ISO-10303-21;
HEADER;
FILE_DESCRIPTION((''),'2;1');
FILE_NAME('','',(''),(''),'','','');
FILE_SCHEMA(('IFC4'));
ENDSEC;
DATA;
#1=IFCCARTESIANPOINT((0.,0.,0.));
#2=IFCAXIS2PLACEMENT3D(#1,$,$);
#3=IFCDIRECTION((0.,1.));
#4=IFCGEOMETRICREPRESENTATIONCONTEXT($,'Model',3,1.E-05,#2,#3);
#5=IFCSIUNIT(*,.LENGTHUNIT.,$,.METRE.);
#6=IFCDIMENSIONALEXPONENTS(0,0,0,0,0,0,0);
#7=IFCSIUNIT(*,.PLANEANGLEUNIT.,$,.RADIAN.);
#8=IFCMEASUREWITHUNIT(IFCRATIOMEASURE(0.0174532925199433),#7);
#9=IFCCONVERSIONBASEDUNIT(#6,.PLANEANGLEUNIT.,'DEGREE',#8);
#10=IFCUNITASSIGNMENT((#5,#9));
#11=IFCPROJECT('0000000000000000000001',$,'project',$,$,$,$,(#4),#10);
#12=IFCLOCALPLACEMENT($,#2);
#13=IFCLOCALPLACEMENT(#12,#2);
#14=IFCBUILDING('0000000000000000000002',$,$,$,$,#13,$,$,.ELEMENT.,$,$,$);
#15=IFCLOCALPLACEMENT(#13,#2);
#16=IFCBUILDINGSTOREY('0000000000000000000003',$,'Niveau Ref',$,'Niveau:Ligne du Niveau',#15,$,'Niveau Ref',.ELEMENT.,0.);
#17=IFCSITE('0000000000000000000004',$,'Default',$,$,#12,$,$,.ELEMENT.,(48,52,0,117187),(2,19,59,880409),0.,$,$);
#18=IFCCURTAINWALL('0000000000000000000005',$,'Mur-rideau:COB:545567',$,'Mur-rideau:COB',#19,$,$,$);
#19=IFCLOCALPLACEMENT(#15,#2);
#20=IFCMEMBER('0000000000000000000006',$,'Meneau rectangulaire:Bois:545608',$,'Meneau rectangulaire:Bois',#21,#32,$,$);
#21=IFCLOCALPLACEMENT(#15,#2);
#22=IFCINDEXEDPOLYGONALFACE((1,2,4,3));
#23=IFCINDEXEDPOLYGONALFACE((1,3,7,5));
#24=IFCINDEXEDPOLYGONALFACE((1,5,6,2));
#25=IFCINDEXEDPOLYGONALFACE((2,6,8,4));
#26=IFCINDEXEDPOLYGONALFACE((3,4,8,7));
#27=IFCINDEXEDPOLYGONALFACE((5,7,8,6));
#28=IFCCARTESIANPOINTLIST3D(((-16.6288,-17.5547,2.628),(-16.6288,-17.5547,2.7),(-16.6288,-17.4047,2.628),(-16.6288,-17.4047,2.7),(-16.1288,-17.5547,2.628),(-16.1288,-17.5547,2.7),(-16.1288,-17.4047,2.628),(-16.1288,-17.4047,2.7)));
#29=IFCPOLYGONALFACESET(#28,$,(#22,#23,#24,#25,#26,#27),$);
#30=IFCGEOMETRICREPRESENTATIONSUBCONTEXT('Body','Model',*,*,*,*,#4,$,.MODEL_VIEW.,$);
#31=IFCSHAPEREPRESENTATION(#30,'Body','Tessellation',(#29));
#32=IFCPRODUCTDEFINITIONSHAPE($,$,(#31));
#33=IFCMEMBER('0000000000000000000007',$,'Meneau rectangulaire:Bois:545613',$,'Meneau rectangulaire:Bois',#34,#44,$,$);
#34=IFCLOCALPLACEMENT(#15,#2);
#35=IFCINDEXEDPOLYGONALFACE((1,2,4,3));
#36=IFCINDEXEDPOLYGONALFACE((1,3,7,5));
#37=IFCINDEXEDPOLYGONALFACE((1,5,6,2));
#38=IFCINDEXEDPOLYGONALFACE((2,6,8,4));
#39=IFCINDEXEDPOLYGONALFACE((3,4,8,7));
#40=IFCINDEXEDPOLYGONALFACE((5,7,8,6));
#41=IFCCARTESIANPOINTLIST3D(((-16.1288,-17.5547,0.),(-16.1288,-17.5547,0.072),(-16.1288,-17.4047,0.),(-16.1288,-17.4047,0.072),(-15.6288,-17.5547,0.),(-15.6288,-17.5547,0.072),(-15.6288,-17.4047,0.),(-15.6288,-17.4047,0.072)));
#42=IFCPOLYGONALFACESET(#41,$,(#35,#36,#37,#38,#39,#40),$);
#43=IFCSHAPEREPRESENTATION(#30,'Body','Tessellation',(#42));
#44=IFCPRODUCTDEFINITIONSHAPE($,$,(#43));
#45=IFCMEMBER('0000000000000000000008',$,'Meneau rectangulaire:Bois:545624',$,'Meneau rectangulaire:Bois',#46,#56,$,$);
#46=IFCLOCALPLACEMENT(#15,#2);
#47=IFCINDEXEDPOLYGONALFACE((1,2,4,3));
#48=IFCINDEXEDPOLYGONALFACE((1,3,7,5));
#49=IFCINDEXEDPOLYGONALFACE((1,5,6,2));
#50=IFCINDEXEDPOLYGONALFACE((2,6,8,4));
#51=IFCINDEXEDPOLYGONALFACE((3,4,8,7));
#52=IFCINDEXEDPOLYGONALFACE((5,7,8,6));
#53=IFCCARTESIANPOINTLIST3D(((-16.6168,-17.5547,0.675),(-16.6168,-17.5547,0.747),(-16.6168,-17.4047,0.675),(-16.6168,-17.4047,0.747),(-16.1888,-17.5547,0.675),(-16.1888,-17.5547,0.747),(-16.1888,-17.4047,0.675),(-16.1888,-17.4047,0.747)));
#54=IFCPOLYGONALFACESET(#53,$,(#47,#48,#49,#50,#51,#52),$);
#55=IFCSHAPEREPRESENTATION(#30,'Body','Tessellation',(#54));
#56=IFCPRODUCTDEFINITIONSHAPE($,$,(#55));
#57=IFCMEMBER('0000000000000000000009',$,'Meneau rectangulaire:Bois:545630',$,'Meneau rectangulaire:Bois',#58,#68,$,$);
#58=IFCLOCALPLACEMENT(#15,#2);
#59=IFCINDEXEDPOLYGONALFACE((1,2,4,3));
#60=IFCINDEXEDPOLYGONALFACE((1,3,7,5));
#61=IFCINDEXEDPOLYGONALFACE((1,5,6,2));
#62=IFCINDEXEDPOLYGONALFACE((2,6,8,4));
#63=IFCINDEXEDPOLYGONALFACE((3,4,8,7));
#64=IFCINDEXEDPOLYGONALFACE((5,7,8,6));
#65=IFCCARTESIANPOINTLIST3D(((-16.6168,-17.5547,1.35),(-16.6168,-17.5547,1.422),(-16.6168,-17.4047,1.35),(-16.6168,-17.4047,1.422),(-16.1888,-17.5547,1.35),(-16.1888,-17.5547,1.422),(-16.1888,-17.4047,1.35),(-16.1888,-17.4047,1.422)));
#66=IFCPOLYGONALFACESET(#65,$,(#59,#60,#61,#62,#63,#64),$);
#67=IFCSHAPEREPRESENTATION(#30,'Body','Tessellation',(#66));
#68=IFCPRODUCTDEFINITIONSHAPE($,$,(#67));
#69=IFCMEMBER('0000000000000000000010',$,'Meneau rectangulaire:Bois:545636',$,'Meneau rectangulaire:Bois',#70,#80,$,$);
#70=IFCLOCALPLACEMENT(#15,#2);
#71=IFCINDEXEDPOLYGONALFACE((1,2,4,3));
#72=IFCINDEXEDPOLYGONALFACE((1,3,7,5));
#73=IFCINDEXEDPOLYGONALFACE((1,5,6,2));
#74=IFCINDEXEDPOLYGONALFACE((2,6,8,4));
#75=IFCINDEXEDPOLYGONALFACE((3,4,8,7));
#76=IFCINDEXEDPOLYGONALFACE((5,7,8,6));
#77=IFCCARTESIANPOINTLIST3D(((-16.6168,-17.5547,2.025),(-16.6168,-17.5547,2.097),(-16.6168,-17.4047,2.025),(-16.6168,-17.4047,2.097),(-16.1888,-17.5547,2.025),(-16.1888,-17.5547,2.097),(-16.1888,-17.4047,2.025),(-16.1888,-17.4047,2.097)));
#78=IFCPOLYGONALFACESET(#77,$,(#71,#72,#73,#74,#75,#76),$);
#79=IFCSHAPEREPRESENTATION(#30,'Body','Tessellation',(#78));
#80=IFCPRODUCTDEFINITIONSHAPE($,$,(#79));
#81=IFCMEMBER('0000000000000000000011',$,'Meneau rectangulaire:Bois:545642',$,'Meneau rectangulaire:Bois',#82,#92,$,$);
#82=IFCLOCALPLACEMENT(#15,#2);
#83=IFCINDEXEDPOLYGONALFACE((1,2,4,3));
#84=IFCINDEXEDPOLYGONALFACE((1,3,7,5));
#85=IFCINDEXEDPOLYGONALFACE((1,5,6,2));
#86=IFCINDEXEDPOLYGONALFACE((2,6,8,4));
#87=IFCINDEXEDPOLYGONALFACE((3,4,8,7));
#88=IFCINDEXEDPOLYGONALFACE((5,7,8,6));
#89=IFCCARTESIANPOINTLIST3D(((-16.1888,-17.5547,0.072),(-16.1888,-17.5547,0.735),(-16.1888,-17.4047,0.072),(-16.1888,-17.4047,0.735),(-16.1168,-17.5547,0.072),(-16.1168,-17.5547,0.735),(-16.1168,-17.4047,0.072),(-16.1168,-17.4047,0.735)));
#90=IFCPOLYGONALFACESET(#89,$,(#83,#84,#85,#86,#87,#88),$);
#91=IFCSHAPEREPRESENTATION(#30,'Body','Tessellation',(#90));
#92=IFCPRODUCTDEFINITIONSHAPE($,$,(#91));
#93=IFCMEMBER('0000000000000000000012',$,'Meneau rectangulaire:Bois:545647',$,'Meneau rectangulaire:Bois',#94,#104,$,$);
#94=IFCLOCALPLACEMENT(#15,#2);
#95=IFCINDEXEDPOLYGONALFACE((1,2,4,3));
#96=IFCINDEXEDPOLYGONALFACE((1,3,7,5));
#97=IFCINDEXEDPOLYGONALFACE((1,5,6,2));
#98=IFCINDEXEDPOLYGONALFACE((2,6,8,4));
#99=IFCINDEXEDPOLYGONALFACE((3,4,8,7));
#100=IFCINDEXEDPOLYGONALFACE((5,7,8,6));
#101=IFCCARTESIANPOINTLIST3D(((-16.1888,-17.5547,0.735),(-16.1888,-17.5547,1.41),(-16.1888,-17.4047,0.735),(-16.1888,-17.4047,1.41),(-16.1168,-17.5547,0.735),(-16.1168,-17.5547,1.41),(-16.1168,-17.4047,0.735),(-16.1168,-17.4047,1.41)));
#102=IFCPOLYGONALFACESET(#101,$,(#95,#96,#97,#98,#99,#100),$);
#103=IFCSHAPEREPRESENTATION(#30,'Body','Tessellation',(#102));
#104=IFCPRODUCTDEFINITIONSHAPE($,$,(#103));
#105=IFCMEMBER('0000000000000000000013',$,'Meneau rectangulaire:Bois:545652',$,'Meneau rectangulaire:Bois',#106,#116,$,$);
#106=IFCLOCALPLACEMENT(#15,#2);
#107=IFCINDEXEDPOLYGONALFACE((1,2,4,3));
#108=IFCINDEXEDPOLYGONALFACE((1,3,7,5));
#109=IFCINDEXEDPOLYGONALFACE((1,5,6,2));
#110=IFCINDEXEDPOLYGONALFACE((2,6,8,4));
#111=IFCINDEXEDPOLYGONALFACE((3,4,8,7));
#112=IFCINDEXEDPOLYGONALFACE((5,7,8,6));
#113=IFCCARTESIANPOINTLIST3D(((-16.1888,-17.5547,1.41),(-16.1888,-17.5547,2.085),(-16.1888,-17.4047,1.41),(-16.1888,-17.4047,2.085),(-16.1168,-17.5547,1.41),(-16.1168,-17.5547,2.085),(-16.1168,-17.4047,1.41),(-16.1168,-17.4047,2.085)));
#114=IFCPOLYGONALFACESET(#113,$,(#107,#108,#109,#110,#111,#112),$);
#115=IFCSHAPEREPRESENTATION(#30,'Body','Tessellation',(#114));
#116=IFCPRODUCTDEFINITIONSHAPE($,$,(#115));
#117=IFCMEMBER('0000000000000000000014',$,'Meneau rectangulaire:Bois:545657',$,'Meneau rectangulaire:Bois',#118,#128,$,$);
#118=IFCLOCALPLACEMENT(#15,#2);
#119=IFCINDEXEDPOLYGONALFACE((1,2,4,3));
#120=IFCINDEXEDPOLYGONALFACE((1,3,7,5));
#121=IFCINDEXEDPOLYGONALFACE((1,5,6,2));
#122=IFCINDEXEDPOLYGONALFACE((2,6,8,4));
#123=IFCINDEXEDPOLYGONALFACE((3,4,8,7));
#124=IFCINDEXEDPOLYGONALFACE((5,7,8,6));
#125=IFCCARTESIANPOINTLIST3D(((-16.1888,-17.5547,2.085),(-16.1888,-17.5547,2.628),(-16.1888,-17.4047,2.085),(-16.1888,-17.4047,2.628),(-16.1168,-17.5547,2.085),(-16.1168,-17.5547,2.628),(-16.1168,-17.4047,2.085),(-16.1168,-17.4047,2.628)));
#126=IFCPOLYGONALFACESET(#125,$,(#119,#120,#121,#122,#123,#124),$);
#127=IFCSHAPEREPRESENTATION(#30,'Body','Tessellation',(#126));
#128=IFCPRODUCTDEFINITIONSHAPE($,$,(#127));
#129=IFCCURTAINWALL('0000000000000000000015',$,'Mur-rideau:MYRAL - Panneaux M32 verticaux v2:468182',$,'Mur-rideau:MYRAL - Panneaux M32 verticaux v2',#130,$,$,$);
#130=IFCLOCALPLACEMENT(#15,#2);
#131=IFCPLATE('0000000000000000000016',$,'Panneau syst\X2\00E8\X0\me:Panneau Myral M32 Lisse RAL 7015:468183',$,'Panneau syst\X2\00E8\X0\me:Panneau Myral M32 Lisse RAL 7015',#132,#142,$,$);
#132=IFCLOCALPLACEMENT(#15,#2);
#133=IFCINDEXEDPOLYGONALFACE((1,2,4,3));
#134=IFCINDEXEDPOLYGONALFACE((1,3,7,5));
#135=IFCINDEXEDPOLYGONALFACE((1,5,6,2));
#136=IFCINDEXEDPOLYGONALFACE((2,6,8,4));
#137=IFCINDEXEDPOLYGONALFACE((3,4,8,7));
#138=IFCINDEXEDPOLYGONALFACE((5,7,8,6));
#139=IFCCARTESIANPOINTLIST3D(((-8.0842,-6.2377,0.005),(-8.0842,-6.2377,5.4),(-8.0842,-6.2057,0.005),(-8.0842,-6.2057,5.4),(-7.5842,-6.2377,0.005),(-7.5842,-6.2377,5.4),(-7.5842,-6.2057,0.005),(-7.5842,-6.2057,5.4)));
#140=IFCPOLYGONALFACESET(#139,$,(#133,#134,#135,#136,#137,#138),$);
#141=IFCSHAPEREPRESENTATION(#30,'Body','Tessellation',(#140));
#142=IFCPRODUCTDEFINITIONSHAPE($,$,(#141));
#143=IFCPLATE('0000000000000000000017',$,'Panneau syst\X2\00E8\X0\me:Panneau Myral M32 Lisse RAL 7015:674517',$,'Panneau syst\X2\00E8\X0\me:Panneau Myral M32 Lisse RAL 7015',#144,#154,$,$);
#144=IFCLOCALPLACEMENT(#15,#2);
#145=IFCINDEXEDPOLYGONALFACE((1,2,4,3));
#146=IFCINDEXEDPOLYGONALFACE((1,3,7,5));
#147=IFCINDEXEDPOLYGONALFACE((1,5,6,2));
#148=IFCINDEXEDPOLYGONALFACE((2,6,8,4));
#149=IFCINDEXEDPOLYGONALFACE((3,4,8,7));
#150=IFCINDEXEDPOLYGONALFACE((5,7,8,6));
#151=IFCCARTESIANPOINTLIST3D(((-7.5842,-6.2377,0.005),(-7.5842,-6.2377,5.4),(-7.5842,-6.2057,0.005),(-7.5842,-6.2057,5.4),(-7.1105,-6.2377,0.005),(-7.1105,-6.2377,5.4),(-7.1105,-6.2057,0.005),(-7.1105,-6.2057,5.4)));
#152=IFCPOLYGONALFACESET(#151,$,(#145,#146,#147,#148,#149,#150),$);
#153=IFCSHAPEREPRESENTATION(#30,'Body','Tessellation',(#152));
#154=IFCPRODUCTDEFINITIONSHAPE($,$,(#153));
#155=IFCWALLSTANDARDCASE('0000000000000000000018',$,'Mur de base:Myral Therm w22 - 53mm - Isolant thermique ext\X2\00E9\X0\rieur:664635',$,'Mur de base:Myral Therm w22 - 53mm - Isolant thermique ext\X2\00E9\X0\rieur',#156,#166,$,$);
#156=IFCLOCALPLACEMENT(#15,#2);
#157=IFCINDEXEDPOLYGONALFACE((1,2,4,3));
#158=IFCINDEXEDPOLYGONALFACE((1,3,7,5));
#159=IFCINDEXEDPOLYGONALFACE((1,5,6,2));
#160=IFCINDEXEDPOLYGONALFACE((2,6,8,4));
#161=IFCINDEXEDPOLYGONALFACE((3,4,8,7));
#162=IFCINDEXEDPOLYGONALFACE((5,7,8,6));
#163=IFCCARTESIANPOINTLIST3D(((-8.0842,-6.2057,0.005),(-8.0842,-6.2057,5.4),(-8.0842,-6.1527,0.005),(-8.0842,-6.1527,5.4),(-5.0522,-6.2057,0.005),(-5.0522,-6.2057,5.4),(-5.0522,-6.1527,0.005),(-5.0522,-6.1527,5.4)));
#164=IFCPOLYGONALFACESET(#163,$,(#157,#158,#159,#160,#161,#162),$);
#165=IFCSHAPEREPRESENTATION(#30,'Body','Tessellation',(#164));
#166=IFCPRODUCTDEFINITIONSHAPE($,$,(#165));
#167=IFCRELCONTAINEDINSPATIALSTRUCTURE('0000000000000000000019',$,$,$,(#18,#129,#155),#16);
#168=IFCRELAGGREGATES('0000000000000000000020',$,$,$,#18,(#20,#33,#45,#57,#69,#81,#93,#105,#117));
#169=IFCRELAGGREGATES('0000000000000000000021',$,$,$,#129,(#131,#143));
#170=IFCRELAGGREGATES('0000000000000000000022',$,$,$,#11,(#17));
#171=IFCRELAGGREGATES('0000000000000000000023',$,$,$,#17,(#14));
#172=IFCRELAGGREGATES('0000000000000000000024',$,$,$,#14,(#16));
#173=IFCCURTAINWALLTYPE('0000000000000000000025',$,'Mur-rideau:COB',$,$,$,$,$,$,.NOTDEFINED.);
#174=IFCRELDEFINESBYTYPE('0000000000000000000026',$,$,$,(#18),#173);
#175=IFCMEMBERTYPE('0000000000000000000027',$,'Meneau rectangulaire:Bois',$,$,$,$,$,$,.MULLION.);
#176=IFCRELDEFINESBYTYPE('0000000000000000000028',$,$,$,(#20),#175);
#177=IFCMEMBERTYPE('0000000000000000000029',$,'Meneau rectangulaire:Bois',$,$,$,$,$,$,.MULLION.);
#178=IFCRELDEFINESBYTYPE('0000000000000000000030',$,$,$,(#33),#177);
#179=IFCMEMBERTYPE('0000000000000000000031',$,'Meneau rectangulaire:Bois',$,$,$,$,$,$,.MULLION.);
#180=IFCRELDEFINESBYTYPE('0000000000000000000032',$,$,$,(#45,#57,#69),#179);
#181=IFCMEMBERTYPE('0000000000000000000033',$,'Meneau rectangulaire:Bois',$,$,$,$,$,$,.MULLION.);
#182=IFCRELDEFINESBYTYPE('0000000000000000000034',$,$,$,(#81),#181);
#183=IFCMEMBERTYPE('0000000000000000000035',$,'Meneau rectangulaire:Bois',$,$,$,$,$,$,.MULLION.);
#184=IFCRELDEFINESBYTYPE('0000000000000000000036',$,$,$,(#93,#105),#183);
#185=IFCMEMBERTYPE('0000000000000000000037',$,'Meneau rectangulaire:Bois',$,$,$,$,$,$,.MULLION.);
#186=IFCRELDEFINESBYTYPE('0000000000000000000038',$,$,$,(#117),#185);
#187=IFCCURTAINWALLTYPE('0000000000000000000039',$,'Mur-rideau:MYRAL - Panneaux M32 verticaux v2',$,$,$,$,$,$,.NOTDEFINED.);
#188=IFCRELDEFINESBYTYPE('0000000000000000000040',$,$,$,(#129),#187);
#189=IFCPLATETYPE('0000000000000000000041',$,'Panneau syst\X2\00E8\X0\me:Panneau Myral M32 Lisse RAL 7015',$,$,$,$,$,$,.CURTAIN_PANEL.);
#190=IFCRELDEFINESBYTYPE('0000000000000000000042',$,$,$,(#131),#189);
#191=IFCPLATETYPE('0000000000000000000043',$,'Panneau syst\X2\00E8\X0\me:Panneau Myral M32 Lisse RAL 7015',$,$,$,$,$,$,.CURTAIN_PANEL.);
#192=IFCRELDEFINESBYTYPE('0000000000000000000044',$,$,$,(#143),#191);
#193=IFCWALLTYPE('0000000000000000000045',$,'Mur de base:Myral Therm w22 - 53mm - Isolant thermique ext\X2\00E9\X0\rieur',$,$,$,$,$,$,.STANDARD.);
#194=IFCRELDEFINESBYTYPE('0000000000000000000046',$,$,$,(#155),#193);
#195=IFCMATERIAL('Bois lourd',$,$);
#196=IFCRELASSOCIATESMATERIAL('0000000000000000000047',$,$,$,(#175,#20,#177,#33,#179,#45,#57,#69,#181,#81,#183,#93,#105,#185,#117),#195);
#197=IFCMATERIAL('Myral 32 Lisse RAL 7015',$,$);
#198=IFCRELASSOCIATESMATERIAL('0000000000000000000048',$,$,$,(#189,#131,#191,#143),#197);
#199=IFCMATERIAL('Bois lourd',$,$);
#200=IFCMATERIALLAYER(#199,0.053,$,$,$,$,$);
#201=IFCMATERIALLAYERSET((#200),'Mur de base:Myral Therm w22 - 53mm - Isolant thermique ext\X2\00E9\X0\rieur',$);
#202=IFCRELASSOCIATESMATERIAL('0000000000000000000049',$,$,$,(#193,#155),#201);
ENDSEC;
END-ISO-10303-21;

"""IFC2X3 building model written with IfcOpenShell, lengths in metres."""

from ifc_helpers import new_model, entity, si_unit, converted_unit, direction, frame, frame_2d, origin, origin_2d_with_axis, place, context, subcontext, project, spatial, rectangle, extrude, source, transform, mapped, material, layer, layer_set, layer_usage, type_object, type_shapes, element, aggregate, save


model = new_model("IFC2X3")

# Units and contexts
model_context = context("Model", 3, precision=1e-05, world=origin(), true_north=direction((0.0, 1.0)))
body_context = subcontext(model_context, "Body", "Model", "MODEL_VIEW")
ifc_project = project(units=[si_unit("LENGTHUNIT", "METRE"), converted_unit("PLANEANGLEUNIT", "DEGREE", entity("IfcRatioMeasure", 0.0174532925199433), si_unit("PLANEANGLEUNIT", "RADIAN"), dimensions=[0, 0, 0, 0, 0, 0, 0])], contexts=[model_context])

# Site, building, storey
site_placement = place(None, origin())
site = spatial("IfcSite", under=ifc_project, at=site_placement, Name="Default", CompositionType="ELEMENT", RefLatitude=(48, 52, 0, 117187), RefLongitude=(2, 19, 59, 880409), RefElevation=0.0)
building_placement = place(site_placement, origin())
building = spatial("IfcBuilding", under=site, at=building_placement, CompositionType="ELEMENT")
storey_placement = place(building_placement, origin())
storey = spatial("IfcBuildingStorey", under=building, at=storey_placement, Name="Niveau Ref", ObjectType="Niveau:Ligne du Niveau", LongName="Niveau Ref", CompositionType="ELEMENT", Elevation=0.0)

# Curtain wall, members
curtain_wall_type_1 = type_object("IfcCurtainWallType", Name="Mur-rideau:COB", PredefinedType="NOTDEFINED")
curtain_wall_1_placement = place(storey_placement, origin())
curtain_wall_1 = element("IfcCurtainWall", 1, at=curtain_wall_1_placement, inside=storey, type_object=curtain_wall_type_1, Name="Mur-rideau:COB:545567", ObjectType="Mur-rideau:COB")
ifc_material_1 = material(Name="Bois lourd")
member_type_1 = type_object("IfcMemberType", Name="Meneau rectangulaire:Bois", PredefinedType="MULLION", material=ifc_material_1)
shared_shape_1 = source(origin(), body_context, "Body", "SweptSolid", [
    extrude(rectangle(XDim=0.15, YDim=0.072, at=origin_2d_with_axis()), frame((-0.036, 0.0, -0.5), z_axis=(0.0, 0.0, 1.0), x_axis=(0.0, -1.0, 0.0)), (0.0, 0.0, 1.0), 0.5),
])
type_shapes(member_type_1, [shared_shape_1])
member_1_placement = place(storey_placement, frame((-16.1288, -17.4797, 2.7), z_axis=(1.0, 0.0, 0.0), x_axis=(0.0, 0.0, 1.0)))
member_1 = element("IfcMember", 2, at=member_1_placement, type_object=member_type_1, material=ifc_material_1, Name="Meneau rectangulaire:Bois:545608", ObjectType="Meneau rectangulaire:Bois", context=body_context, shape_type="MappedRepresentation", body=[
    mapped(shared_shape_1, transform((0.0, 0.0, 0.0), scale=1.0)),
])
member_type_2 = type_object("IfcMemberType", Name="Meneau rectangulaire:Bois", PredefinedType="MULLION", material=ifc_material_1)
shared_shape_2 = source(origin(), body_context, "Body", "SweptSolid", [
    extrude(rectangle(XDim=0.15, YDim=0.072, at=origin_2d_with_axis()), frame((-0.036, 0.0, -0.5), z_axis=(0.0, 0.0, 1.0), x_axis=(0.0, -1.0, 0.0)), (0.0, 0.0, 1.0), 0.5),
])
type_shapes(member_type_2, [shared_shape_2])
member_2_placement = place(storey_placement, frame((-16.1288, -17.4797, 0.0), z_axis=(-1.0, 0.0, 0.0), x_axis=(0.0, 0.0, -1.0)))
member_2 = element("IfcMember", 3, at=member_2_placement, type_object=member_type_2, material=ifc_material_1, Name="Meneau rectangulaire:Bois:545613", ObjectType="Meneau rectangulaire:Bois", context=body_context, shape_type="MappedRepresentation", body=[
    mapped(shared_shape_2, transform((0.0, 0.0, 0.0), scale=1.0)),
])
member_type_3 = type_object("IfcMemberType", Name="Meneau rectangulaire:Bois", PredefinedType="MULLION", material=ifc_material_1)
shared_shape_3 = source(origin(), body_context, "Body", "SweptSolid", [
    extrude(rectangle(XDim=0.15, YDim=0.072, at=origin_2d_with_axis()), frame((-0.024, 0.0, -0.428), z_axis=(0.0, 0.0, 1.0), x_axis=(0.0, -1.0, 0.0)), (0.0, 0.0, 1.0), 0.428),
])
type_shapes(member_type_3, [shared_shape_3])
member_3_placement = place(storey_placement, frame((-16.1888, -17.4797, 0.735), z_axis=(1.0, 0.0, 0.0), x_axis=(0.0, 0.0, 1.0)))
member_3 = element("IfcMember", 4, at=member_3_placement, type_object=member_type_3, material=ifc_material_1, Name="Meneau rectangulaire:Bois:545624", ObjectType="Meneau rectangulaire:Bois", context=body_context, shape_type="MappedRepresentation", body=[
    mapped(shared_shape_3, transform((0.0, 0.0, 0.0), scale=1.0)),
])
member_4_placement = place(storey_placement, frame((-16.1888, -17.4797, 1.41), z_axis=(1.0, 0.0, 0.0), x_axis=(0.0, 0.0, 1.0)))
member_4 = element("IfcMember", 5, at=member_4_placement, type_object=member_type_3, material=ifc_material_1, Name="Meneau rectangulaire:Bois:545630", ObjectType="Meneau rectangulaire:Bois", context=body_context, shape_type="MappedRepresentation", body=[
    mapped(shared_shape_3, transform((0.0, 0.0, 0.0), scale=1.0)),
])
member_5_placement = place(storey_placement, frame((-16.1888, -17.4797, 2.085), z_axis=(1.0, 0.0, 0.0), x_axis=(0.0, 0.0, 1.0)))
member_5 = element("IfcMember", 6, at=member_5_placement, type_object=member_type_3, material=ifc_material_1, Name="Meneau rectangulaire:Bois:545636", ObjectType="Meneau rectangulaire:Bois", context=body_context, shape_type="MappedRepresentation", body=[
    mapped(shared_shape_3, transform((0.0, 0.0, 0.0), scale=1.0)),
])
member_type_4 = type_object("IfcMemberType", Name="Meneau rectangulaire:Bois", PredefinedType="MULLION", material=ifc_material_1)
shared_shape_4 = source(origin(), body_context, "Body", "SweptSolid", [
    extrude(rectangle(XDim=0.15, YDim=0.072, at=origin_2d_with_axis()), frame((-0.024, 0.0, -0.663), z_axis=(0.0, 0.0, 1.0), x_axis=(0.0, -1.0, 0.0)), (0.0, 0.0, 1.0), 0.663),
])
type_shapes(member_type_4, [shared_shape_4])
member_6_placement = place(storey_placement, frame((-16.1288, -17.4797, 0.072), z_axis=(0.0, 0.0, -1.0), x_axis=(1.0, 0.0, 0.0)))
member_6 = element("IfcMember", 7, at=member_6_placement, type_object=member_type_4, material=ifc_material_1, Name="Meneau rectangulaire:Bois:545642", ObjectType="Meneau rectangulaire:Bois", context=body_context, shape_type="MappedRepresentation", body=[
    mapped(shared_shape_4, transform((0.0, 0.0, 0.0), scale=1.0)),
])
member_type_5 = type_object("IfcMemberType", Name="Meneau rectangulaire:Bois", PredefinedType="MULLION", material=ifc_material_1)
shared_shape_5 = source(origin(), body_context, "Body", "SweptSolid", [
    extrude(rectangle(XDim=0.15, YDim=0.072, at=origin_2d_with_axis()), frame((-0.024, 0.0, -0.675), z_axis=(0.0, 0.0, 1.0), x_axis=(0.0, -1.0, 0.0)), (0.0, 0.0, 1.0), 0.675),
])
type_shapes(member_type_5, [shared_shape_5])
member_7_placement = place(storey_placement, frame((-16.1288, -17.4797, 0.735), z_axis=(0.0, 0.0, -1.0), x_axis=(1.0, 0.0, 0.0)))
member_7 = element("IfcMember", 8, at=member_7_placement, type_object=member_type_5, material=ifc_material_1, Name="Meneau rectangulaire:Bois:545647", ObjectType="Meneau rectangulaire:Bois", context=body_context, shape_type="MappedRepresentation", body=[
    mapped(shared_shape_5, transform((0.0, 0.0, 0.0), scale=1.0)),
])
member_8_placement = place(storey_placement, frame((-16.1288, -17.4797, 1.41), z_axis=(0.0, 0.0, -1.0), x_axis=(1.0, 0.0, 0.0)))
member_8 = element("IfcMember", 9, at=member_8_placement, type_object=member_type_5, material=ifc_material_1, Name="Meneau rectangulaire:Bois:545652", ObjectType="Meneau rectangulaire:Bois", context=body_context, shape_type="MappedRepresentation", body=[
    mapped(shared_shape_5, transform((0.0, 0.0, 0.0), scale=1.0)),
])
member_type_6 = type_object("IfcMemberType", Name="Meneau rectangulaire:Bois", PredefinedType="MULLION", material=ifc_material_1)
shared_shape_6 = source(origin(), body_context, "Body", "SweptSolid", [
    extrude(rectangle(XDim=0.15, YDim=0.072, at=origin_2d_with_axis()), frame((-0.024, 0.0, -0.543), z_axis=(0.0, 0.0, 1.0), x_axis=(0.0, -1.0, 0.0)), (0.0, 0.0, 1.0), 0.543),
])
type_shapes(member_type_6, [shared_shape_6])
member_9_placement = place(storey_placement, frame((-16.1288, -17.4797, 2.085), z_axis=(0.0, 0.0, -1.0), x_axis=(1.0, 0.0, 0.0)))
member_9 = element("IfcMember", 10, at=member_9_placement, type_object=member_type_6, material=ifc_material_1, Name="Meneau rectangulaire:Bois:545657", ObjectType="Meneau rectangulaire:Bois", context=body_context, shape_type="MappedRepresentation", body=[
    mapped(shared_shape_6, transform((0.0, 0.0, 0.0), scale=1.0)),
])
aggregate(curtain_wall_1, [member_1, member_2, member_3, member_4, member_5, member_6, member_7, member_8, member_9])

# Curtain wall, plates
curtain_wall_type_2 = type_object("IfcCurtainWallType", Name="Mur-rideau:MYRAL - Panneaux M32 verticaux v2", PredefinedType="NOTDEFINED")
curtain_wall_2_placement = place(storey_placement, origin())
curtain_wall_2 = element("IfcCurtainWall", 11, at=curtain_wall_2_placement, inside=storey, type_object=curtain_wall_type_2, Name="Mur-rideau:MYRAL - Panneaux M32 verticaux v2:468182", ObjectType="Mur-rideau:MYRAL - Panneaux M32 verticaux v2")
ifc_material_2 = material(Name="Myral 32 Lisse RAL 7015")
plate_type_1 = type_object("IfcPlateType", Name="Panneau système:Panneau Myral M32 Lisse RAL 7015", PredefinedType="CURTAIN_PANEL", material=ifc_material_2)
shared_shape_7 = source(origin(), body_context, "Body", "SweptSolid", [
    extrude(rectangle(XDim=0.032, YDim=0.5, at=origin_2d_with_axis()), frame((0.0, -0.016, 0.0), z_axis=(0.0, 0.0, 1.0), x_axis=(0.0, 1.0, 0.0)), (0.0, 0.0, 1.0), 5.395),
])
type_shapes(plate_type_1, [shared_shape_7])
plate_1_placement = place(curtain_wall_2_placement, frame((-7.8342, -6.2057, 0.005)))
plate_1 = element("IfcPlate", 12, at=plate_1_placement, type_object=plate_type_1, material=ifc_material_2, Name="Panneau système:Panneau Myral M32 Lisse RAL 7015:468183", ObjectType="Panneau système:Panneau Myral M32 Lisse RAL 7015", context=body_context, shape_type="MappedRepresentation", body=[
    mapped(shared_shape_7, transform((0.0, 0.0, 0.0), scale=1.0)),
])
plate_type_2 = type_object("IfcPlateType", Name="Panneau système:Panneau Myral M32 Lisse RAL 7015", PredefinedType="CURTAIN_PANEL", material=ifc_material_2)
shared_shape_8 = source(origin(), body_context, "Body", "SweptSolid", [
    extrude(rectangle(XDim=0.032, YDim=0.4737, at=origin_2d_with_axis()), frame((0.0, -0.016, 0.0), z_axis=(0.0, 0.0, 1.0), x_axis=(0.0, 1.0, 0.0)), (0.0, 0.0, 1.0), 5.395),
])
type_shapes(plate_type_2, [shared_shape_8])
plate_2_placement = place(curtain_wall_2_placement, frame((-7.3474, -6.2057, 0.005)))
plate_2 = element("IfcPlate", 13, at=plate_2_placement, type_object=plate_type_2, material=ifc_material_2, Name="Panneau système:Panneau Myral M32 Lisse RAL 7015:674517", ObjectType="Panneau système:Panneau Myral M32 Lisse RAL 7015", context=body_context, shape_type="MappedRepresentation", body=[
    mapped(shared_shape_8, transform((0.0, 0.0, 0.0), scale=1.0)),
])
aggregate(curtain_wall_2, [plate_1, plate_2])

# Wall
ifc_material_3 = material(Name="Bois lourd")
ifc_layer = layer(ifc_material_3, 0.053)
ifc_layer_set = layer_set([ifc_layer], Name="Mur de base:Myral Therm w22 - 53mm - Isolant thermique extérieur")
ifc_layer_usage = layer_usage(ifc_layer_set, "AXIS2", "NEGATIVE", 0.0265)
wall_type = type_object("IfcWallType", Name="Mur de base:Myral Therm w22 - 53mm - Isolant thermique extérieur", PredefinedType="STANDARD", material=ifc_layer_set)
wall_placement = place(storey_placement, frame((-8.0842, -6.1792, 0.005)))
element("IfcWallStandardCase", 14, at=wall_placement, inside=storey, type_object=wall_type, material=ifc_layer_usage, Name="Mur de base:Myral Therm w22 - 53mm - Isolant thermique extérieur:664635", ObjectType="Mur de base:Myral Therm w22 - 53mm - Isolant thermique extérieur", context=body_context, shape_type="SweptSolid", body=[
    extrude(rectangle(XDim=3.032, YDim=0.053, at=frame_2d((1.516, 0.0), x_axis=(-1.0, 0.0))), origin(), (0.0, 0.0, 1.0), 5.395),
])

save(model, "model.ifc")
